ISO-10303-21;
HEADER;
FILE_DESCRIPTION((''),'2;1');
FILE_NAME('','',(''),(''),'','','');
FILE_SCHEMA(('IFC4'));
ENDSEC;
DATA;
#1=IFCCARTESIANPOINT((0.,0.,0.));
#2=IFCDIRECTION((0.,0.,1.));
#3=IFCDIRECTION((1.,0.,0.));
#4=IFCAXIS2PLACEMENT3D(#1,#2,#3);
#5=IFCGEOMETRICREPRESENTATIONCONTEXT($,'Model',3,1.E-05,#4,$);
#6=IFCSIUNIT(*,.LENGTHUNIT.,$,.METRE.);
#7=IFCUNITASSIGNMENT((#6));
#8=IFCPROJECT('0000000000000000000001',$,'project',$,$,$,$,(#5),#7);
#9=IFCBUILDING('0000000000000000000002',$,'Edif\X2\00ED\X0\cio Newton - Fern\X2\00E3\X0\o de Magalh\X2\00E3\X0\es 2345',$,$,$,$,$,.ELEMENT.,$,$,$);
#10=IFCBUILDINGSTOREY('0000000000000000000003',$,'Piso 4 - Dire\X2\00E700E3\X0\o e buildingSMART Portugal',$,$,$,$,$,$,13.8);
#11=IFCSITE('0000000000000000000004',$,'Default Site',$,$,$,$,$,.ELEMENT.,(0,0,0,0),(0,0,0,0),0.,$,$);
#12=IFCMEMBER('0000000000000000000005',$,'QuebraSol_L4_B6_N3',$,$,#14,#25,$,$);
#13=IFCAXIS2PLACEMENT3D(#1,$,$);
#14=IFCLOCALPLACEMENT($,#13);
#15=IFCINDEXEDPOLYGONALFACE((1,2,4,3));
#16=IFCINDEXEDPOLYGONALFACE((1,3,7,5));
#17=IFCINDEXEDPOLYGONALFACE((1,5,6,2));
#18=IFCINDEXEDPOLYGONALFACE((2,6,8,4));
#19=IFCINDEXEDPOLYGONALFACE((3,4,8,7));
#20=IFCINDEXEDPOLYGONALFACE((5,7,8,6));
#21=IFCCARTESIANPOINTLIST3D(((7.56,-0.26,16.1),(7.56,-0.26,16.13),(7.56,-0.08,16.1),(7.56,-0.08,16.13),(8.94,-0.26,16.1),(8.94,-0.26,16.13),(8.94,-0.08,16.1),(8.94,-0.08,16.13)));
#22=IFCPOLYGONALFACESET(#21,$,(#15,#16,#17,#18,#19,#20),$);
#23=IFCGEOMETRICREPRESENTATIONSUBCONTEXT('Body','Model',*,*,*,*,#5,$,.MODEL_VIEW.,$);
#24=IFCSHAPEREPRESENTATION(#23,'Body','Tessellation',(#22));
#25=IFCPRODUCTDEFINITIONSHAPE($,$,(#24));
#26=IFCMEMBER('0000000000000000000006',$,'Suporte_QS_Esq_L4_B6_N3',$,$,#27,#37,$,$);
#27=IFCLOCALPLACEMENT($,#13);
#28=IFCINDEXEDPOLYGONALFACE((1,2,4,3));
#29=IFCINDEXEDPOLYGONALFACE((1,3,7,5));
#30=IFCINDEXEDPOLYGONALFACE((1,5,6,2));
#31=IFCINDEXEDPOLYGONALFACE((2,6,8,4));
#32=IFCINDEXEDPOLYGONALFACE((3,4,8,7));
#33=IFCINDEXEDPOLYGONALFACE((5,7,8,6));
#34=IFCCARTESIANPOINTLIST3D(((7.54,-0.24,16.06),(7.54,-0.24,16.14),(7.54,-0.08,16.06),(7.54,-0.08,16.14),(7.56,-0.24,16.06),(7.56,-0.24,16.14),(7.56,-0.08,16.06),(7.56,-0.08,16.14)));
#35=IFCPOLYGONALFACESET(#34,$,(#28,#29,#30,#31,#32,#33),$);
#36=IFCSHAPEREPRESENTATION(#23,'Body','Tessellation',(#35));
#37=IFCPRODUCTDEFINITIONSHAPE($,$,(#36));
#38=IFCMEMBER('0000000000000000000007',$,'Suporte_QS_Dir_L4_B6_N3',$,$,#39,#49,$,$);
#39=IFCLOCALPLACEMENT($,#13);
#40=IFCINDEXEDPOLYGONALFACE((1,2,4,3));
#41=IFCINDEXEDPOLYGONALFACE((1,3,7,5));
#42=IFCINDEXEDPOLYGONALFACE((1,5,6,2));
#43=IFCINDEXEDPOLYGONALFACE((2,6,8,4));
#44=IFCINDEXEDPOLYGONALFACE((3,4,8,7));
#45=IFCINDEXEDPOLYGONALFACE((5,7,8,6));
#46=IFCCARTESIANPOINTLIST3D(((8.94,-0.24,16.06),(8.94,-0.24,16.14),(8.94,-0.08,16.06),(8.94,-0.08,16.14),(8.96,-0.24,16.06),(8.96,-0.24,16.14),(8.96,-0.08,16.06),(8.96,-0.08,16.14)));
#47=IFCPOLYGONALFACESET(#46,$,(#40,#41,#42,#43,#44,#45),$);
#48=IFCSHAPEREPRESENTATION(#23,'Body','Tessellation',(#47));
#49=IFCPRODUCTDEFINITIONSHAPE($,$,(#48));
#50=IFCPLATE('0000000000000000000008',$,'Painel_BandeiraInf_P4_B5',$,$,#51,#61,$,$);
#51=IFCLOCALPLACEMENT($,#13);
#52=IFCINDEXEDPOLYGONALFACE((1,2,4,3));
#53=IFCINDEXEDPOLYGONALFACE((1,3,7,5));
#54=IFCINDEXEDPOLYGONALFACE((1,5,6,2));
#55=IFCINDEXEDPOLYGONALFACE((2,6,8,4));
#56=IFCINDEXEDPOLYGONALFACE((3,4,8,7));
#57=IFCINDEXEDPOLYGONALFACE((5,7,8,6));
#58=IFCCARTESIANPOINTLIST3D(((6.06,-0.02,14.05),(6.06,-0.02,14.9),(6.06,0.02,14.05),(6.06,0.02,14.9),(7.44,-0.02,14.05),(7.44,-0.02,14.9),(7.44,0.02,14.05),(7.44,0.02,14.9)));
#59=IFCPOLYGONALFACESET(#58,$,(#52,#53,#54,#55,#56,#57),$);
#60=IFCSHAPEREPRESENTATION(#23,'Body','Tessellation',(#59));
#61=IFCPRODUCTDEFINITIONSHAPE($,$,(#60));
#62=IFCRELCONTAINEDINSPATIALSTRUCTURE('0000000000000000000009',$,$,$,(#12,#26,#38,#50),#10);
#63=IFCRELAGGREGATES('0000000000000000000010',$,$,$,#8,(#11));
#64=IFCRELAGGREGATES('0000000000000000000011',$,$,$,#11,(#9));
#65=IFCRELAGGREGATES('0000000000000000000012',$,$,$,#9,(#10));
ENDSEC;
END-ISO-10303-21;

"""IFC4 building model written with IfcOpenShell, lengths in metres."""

from ifc_helpers import new_model, si_unit, frame, frame_2d, origin_with_axes, place, context, subcontext, project, spatial, rectangle, extrude, element, save


model = new_model("IFC4")

# Units and contexts
model_context = context("Model", 3, precision=1e-05, world=origin_with_axes())
body_context = subcontext(model_context, "Body", "Model", "MODEL_VIEW")
ifc_project = project(units=[si_unit("LENGTHUNIT", "METRE")], contexts=[model_context])

# Site, building, storey
site = spatial("IfcSite", under=ifc_project, Name="Default Site", CompositionType="ELEMENT", RefLatitude=(0, 0, 0, 0), RefLongitude=(0, 0, 0, 0), RefElevation=0.0)
building = spatial("IfcBuilding", under=site, Name="Edifício Newton - Fernão de Magalhães 2345", CompositionType="ELEMENT")
storey = spatial("IfcBuildingStorey", under=building, Name="Piso 4 - Direção e buildingSMART Portugal", Elevation=13.8)

# Members
member_1_placement = place(None, frame((7.56, -0.26, 16.1), z_axis=(0.0, 0.0, 1.0), x_axis=(1.0, 0.0, 0.0)))
element("IfcMember", 1, at=member_1_placement, inside=storey, Name="QuebraSol_L4_B6_N3", context=body_context, shape_type="SweptSolid", body=[
    extrude(rectangle(XDim=1.38, YDim=0.18, at=frame_2d((0.69, 0.09))), origin_with_axes(), (0.0, 0.0, 1.0), 0.03),
])
for number, where, z_axis, x_axis, name in (
    (2, (7.54, -0.24, 16.06), (0.0, 0.0, 1.0), (1.0, 0.0, 0.0), "Suporte_QS_Esq_L4_B6_N3"),
    (3, (8.94, -0.24, 16.06), (0.0, 0.0, 1.0), (1.0, 0.0, 0.0), "Suporte_QS_Dir_L4_B6_N3"),
):
    element("IfcMember", number, at=place(None, frame(where, z_axis=z_axis, x_axis=x_axis)), inside=storey, Name=name, context=body_context, shape_type="SweptSolid", body=[
        extrude(rectangle(XDim=0.02, YDim=0.16, at=frame_2d((0.01, 0.08))), origin_with_axes(), (0.0, 0.0, 1.0), 0.08),
    ])

# Plate
plate_placement = place(None, frame((6.06, -0.02, 14.05), z_axis=(0.0, 0.0, 1.0), x_axis=(1.0, 0.0, 0.0)))
element("IfcPlate", 4, at=plate_placement, inside=storey, Name="Painel_BandeiraInf_P4_B5", context=body_context, shape_type="SweptSolid", body=[
    extrude(rectangle(XDim=1.38, YDim=0.04, at=frame_2d((0.69, 0.02))), origin_with_axes(), (0.0, 0.0, 1.0), 0.85),
])

save(model, "model.ifc")
